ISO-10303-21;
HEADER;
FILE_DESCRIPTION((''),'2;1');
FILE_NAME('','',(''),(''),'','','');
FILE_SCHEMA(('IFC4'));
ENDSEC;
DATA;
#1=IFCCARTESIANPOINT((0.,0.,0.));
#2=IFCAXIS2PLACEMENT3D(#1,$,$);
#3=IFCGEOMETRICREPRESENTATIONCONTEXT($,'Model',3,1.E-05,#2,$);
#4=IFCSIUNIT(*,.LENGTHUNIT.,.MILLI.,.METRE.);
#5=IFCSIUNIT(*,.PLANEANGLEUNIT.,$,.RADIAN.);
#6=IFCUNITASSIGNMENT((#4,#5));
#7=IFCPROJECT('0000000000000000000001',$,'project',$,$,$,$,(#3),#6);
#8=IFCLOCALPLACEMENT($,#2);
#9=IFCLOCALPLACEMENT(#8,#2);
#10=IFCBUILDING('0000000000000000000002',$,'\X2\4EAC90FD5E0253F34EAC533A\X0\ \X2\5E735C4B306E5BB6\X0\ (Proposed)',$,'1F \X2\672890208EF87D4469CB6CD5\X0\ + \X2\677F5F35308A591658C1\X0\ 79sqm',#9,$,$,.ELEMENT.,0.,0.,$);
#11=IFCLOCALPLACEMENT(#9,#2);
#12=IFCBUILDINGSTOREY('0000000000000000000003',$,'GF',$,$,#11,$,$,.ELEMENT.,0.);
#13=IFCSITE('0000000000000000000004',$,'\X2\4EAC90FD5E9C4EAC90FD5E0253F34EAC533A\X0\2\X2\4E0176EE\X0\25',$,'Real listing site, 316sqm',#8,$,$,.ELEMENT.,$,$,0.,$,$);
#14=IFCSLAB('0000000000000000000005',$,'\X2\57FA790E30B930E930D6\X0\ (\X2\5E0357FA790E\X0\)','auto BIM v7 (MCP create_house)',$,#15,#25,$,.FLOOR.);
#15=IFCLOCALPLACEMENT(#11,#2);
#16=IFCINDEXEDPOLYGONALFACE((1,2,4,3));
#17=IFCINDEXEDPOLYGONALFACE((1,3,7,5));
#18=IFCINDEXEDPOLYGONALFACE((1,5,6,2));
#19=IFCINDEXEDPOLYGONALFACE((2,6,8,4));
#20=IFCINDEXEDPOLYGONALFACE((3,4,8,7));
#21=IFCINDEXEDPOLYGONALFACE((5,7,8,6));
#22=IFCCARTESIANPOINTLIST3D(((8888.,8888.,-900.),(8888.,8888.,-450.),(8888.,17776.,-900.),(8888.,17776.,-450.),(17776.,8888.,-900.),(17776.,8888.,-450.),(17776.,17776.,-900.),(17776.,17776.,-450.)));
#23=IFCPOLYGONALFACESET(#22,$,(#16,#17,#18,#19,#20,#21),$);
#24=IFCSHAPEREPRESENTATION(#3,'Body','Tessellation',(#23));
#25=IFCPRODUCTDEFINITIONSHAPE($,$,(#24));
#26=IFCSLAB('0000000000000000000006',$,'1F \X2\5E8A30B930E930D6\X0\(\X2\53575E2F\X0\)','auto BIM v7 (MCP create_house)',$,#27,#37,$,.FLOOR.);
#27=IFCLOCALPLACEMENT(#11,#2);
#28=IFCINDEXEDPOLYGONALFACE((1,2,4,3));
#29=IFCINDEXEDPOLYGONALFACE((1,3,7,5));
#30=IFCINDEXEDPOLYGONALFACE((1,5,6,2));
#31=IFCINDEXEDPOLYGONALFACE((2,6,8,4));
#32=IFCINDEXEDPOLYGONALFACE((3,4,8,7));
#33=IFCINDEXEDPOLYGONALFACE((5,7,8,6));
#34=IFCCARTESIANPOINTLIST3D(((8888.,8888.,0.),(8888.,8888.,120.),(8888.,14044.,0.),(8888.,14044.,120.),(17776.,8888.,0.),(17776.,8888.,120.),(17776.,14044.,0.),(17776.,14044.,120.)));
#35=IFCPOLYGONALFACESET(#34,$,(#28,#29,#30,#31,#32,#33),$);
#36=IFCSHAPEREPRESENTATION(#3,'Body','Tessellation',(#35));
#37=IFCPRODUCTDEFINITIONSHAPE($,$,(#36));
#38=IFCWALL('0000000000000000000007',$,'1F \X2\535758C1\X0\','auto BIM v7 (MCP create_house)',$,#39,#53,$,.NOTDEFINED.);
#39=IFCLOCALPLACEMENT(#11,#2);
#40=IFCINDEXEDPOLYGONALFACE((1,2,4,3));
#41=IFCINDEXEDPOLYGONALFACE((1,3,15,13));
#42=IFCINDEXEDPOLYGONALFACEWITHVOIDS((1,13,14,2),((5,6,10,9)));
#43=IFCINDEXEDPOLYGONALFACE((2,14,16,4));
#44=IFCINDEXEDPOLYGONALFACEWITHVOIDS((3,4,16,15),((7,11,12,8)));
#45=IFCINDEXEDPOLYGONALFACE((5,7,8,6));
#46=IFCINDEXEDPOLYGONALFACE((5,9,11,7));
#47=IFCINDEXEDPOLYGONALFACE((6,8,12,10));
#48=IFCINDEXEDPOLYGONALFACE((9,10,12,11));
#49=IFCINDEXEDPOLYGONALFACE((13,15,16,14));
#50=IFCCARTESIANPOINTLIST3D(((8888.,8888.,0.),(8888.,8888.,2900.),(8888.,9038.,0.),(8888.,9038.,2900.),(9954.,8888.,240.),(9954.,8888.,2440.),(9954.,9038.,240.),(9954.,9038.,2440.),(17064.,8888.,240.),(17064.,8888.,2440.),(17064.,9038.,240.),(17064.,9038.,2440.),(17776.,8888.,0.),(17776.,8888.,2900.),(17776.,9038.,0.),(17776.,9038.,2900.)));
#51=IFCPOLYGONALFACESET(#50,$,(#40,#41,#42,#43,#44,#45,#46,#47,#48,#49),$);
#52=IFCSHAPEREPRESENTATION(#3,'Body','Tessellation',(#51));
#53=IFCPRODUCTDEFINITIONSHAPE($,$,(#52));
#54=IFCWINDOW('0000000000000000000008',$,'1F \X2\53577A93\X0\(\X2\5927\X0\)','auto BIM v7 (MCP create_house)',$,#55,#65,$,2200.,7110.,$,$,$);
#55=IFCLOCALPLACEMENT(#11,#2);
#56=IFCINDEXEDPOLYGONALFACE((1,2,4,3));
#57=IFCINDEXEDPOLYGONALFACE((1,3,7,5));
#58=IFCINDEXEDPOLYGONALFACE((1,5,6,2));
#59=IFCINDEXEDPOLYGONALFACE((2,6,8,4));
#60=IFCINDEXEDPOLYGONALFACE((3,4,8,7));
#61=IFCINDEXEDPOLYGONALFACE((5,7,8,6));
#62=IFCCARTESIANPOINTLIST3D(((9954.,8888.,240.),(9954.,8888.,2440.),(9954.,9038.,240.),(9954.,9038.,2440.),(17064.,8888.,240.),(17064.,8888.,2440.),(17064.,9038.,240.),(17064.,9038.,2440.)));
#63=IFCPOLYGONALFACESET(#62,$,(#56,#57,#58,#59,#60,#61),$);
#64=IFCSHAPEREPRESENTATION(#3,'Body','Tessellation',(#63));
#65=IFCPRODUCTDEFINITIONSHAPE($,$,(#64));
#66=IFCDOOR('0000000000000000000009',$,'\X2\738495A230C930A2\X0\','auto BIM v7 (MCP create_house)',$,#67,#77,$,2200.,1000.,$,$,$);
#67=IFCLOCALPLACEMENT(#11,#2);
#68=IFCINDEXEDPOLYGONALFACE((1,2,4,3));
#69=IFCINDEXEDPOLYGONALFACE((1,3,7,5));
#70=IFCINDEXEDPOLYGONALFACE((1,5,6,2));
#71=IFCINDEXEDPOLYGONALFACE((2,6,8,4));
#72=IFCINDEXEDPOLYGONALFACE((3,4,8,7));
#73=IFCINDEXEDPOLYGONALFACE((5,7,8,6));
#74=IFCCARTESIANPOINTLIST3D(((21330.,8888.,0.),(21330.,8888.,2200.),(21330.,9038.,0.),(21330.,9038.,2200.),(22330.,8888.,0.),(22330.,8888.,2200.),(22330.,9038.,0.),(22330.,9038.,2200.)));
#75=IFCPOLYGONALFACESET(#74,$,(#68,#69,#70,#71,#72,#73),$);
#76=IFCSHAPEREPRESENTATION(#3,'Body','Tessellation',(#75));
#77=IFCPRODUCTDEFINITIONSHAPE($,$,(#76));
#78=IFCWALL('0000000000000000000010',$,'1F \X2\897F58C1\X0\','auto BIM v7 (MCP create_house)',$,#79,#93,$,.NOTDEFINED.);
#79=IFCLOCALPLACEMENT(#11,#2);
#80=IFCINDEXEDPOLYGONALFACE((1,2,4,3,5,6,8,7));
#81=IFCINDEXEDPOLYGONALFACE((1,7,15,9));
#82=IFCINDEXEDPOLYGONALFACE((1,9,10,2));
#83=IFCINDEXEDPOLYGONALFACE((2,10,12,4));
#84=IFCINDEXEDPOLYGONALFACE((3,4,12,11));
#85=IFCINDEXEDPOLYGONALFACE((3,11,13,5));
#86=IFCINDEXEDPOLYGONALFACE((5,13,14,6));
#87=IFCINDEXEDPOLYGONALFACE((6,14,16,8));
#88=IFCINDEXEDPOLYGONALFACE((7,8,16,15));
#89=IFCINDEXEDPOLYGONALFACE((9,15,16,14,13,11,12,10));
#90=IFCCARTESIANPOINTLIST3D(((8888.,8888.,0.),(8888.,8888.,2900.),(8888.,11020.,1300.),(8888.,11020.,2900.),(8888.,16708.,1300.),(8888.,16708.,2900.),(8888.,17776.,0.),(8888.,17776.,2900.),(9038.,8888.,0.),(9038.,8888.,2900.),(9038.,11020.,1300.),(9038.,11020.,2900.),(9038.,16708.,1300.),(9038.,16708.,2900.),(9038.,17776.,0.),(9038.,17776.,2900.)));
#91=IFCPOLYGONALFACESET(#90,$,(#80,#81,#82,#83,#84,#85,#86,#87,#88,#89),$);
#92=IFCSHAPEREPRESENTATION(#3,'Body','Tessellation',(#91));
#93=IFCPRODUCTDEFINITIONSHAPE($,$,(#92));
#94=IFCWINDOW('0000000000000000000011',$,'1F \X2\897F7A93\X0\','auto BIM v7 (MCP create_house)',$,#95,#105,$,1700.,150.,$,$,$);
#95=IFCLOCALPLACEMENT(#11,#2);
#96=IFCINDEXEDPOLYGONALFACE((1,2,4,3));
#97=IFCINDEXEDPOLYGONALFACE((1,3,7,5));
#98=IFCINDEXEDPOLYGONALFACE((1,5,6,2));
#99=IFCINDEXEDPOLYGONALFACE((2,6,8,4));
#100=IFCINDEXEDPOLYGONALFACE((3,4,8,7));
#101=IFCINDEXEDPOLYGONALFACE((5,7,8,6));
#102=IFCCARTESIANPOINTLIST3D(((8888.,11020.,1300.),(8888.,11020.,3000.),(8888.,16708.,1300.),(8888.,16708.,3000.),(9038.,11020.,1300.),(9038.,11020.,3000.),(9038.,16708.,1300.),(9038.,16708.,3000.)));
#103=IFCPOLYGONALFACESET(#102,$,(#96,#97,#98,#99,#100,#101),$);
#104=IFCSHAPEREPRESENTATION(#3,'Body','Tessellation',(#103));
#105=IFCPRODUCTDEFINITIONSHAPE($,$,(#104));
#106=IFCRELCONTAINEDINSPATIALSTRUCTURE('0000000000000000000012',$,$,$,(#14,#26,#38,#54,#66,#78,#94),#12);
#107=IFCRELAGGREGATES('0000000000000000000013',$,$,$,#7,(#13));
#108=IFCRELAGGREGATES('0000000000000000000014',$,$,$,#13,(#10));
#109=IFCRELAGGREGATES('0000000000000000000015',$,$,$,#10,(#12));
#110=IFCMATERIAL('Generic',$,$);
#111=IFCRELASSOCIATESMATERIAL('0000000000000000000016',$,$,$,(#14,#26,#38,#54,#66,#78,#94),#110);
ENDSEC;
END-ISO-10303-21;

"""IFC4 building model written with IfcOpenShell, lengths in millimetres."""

from ifc_helpers import new_model, si_unit, frame, frame_2d, origin, place, context, project, spatial, rectangle, extrude, material, element, fill, save


model = new_model("IFC4")

# Units and contexts
model_context = context("Model", 3, precision=1e-05, world=origin())
ifc_project = project(units=[si_unit("LENGTHUNIT", "METRE", prefix="MILLI"), si_unit("PLANEANGLEUNIT", "RADIAN")], contexts=[model_context])

# Site, building, storey
site_placement = place(None, origin())
site = spatial("IfcSite", under=ifc_project, at=site_placement, Name="京都府京都市右京区2丁目25", ObjectType="Real listing site, 316sqm", CompositionType="ELEMENT", RefElevation=0.0)
building_placement = place(site_placement, origin())
building = spatial("IfcBuilding", under=site, at=building_placement, Name="京都市右京区 平屋の家 (Proposed)", ObjectType="1F 木造軸組構法 + 板張り外壁 79sqm", CompositionType="ELEMENT", ElevationOfRefHeight=0.0, ElevationOfTerrain=0.0)
storey_placement = place(building_placement, origin())
storey = spatial("IfcBuildingStorey", under=building, at=storey_placement, Name="GF", CompositionType="ELEMENT", Elevation=0.0)

# Slabs
ifc_material = material(Name="Generic")
slab_1_placement = place(storey_placement, frame((4444.0, 4444.0, -450.0)))
element("IfcSlab", 1, at=slab_1_placement, inside=storey, material=ifc_material, Name="基礎スラブ (布基礎)", Description="auto BIM v7 (MCP create_house)", PredefinedType="FLOOR", context=model_context, shape_type="SweptSolid", body=[
    extrude(rectangle(XDim=8888.0, YDim=8888.0, at=frame_2d((4444.0, 4444.0))), frame((4444.0, 4444.0, -450.0)), (0.0, 0.0, 1.0), 450.0),
])
slab_2_placement = place(storey_placement, frame((4444.0, 4444.0, 0.0)))
element("IfcSlab", 2, at=slab_2_placement, inside=storey, material=ifc_material, Name="1F 床スラブ(南帯)", Description="auto BIM v7 (MCP create_house)", PredefinedType="FLOOR", context=model_context, shape_type="SweptSolid", body=[
    extrude(rectangle(XDim=8888.0, YDim=5156.0, at=frame_2d((4444.0, 2578.0))), frame((4444.0, 4444.0, 0.0)), (0.0, 0.0, 1.0), 120.0),
])

# Wall, openings, window, door
wall_1_placement = place(storey_placement, frame((4444.0, 4444.0, 0.0)))
wall_1 = element("IfcWall", 3, at=wall_1_placement, inside=storey, material=ifc_material, Name="1F 南壁", Description="auto BIM v7 (MCP create_house)", PredefinedType="NOTDEFINED", context=model_context, shape_type="SweptSolid", body=[
    extrude(rectangle(XDim=8888.0, YDim=150.0, at=frame_2d((4444.0, 75.0))), frame((4444.0, 4444.0, 0.0)), (0.0, 0.0, 1.0), 2900.0),
])
opening_1_placement = place(storey_placement, frame((4977.0, 4444.0, 120.0)))
opening_1 = element("IfcOpeningElement", 4, at=opening_1_placement, cuts=wall_1, PredefinedType="NOTDEFINED", context=model_context, shape_type="SweptSolid", body=[
    extrude(rectangle(XDim=7110.0, YDim=150.0, at=frame_2d((3555.0, 75.0))), frame((4977.0, 4444.0, 120.0)), (0.0, 0.0, 1.0), 2200.0),
])
opening_2_placement = place(storey_placement, frame((10665.0, 4444.0, 0.0)))
opening_2 = element("IfcOpeningElement", 5, at=opening_2_placement, cuts=wall_1, PredefinedType="NOTDEFINED", context=model_context, shape_type="SweptSolid", body=[
    extrude(rectangle(XDim=1000.0, YDim=150.0, at=frame_2d((500.0, 75.0))), frame((10665.0, 4444.0, 0.0)), (0.0, 0.0, 1.0), 2200.0),
])
window_1_placement = place(storey_placement, frame((4977.0, 4444.0, 120.0)))
window_1 = element("IfcWindow", 6, at=window_1_placement, inside=storey, material=ifc_material, Name="1F 南窓(大)", Description="auto BIM v7 (MCP create_house)", OverallHeight=2200.0, OverallWidth=7110.0, context=model_context, shape_type="SweptSolid", body=[
    extrude(rectangle(XDim=7110.0, YDim=150.0, at=frame_2d((3555.0, 75.0))), frame((4977.0, 4444.0, 120.0)), (0.0, 0.0, 1.0), 2200.0),
])
fill(opening_1, window_1)
door_placement = place(storey_placement, frame((10665.0, 4444.0, 0.0)))
door = element("IfcDoor", 7, at=door_placement, inside=storey, material=ifc_material, Name="玄関ドア", Description="auto BIM v7 (MCP create_house)", OverallHeight=2200.0, OverallWidth=1000.0, context=model_context, shape_type="SweptSolid", body=[
    extrude(rectangle(XDim=1000.0, YDim=150.0, at=frame_2d((500.0, 75.0))), frame((10665.0, 4444.0, 0.0)), (0.0, 0.0, 1.0), 2200.0),
])
fill(opening_2, door)

# Wall, opening, window
wall_2_placement = place(storey_placement, frame((4444.0, 4444.0, 0.0)))
wall_2 = element("IfcWall", 8, at=wall_2_placement, inside=storey, material=ifc_material, Name="1F 西壁", Description="auto BIM v7 (MCP create_house)", PredefinedType="NOTDEFINED", context=model_context, shape_type="SweptSolid", body=[
    extrude(rectangle(XDim=150.0, YDim=8888.0, at=frame_2d((75.0, 4444.0))), frame((4444.0, 4444.0, 0.0)), (0.0, 0.0, 1.0), 2900.0),
])
opening_3_placement = place(storey_placement, frame((4444.0, 5510.0, 650.0)))
opening_3 = element("IfcOpeningElement", 9, at=opening_3_placement, cuts=wall_2, PredefinedType="NOTDEFINED", context=model_context, shape_type="SweptSolid", body=[
    extrude(rectangle(XDim=150.0, YDim=5688.0, at=frame_2d((75.0, 2844.0))), frame((4444.0, 5510.0, 650.0)), (0.0, 0.0, 1.0), 1700.0),
])
window_2_placement = place(storey_placement, frame((4444.0, 5510.0, 650.0)))
window_2 = element("IfcWindow", 10, at=window_2_placement, inside=storey, material=ifc_material, Name="1F 西窓", Description="auto BIM v7 (MCP create_house)", OverallHeight=1700.0, OverallWidth=150.0, context=model_context, shape_type="SweptSolid", body=[
    extrude(rectangle(XDim=150.0, YDim=5688.0, at=frame_2d((75.0, 2844.0))), frame((4444.0, 5510.0, 650.0)), (0.0, 0.0, 1.0), 1700.0),
])
fill(opening_3, window_2)

save(model, "model.ifc")
